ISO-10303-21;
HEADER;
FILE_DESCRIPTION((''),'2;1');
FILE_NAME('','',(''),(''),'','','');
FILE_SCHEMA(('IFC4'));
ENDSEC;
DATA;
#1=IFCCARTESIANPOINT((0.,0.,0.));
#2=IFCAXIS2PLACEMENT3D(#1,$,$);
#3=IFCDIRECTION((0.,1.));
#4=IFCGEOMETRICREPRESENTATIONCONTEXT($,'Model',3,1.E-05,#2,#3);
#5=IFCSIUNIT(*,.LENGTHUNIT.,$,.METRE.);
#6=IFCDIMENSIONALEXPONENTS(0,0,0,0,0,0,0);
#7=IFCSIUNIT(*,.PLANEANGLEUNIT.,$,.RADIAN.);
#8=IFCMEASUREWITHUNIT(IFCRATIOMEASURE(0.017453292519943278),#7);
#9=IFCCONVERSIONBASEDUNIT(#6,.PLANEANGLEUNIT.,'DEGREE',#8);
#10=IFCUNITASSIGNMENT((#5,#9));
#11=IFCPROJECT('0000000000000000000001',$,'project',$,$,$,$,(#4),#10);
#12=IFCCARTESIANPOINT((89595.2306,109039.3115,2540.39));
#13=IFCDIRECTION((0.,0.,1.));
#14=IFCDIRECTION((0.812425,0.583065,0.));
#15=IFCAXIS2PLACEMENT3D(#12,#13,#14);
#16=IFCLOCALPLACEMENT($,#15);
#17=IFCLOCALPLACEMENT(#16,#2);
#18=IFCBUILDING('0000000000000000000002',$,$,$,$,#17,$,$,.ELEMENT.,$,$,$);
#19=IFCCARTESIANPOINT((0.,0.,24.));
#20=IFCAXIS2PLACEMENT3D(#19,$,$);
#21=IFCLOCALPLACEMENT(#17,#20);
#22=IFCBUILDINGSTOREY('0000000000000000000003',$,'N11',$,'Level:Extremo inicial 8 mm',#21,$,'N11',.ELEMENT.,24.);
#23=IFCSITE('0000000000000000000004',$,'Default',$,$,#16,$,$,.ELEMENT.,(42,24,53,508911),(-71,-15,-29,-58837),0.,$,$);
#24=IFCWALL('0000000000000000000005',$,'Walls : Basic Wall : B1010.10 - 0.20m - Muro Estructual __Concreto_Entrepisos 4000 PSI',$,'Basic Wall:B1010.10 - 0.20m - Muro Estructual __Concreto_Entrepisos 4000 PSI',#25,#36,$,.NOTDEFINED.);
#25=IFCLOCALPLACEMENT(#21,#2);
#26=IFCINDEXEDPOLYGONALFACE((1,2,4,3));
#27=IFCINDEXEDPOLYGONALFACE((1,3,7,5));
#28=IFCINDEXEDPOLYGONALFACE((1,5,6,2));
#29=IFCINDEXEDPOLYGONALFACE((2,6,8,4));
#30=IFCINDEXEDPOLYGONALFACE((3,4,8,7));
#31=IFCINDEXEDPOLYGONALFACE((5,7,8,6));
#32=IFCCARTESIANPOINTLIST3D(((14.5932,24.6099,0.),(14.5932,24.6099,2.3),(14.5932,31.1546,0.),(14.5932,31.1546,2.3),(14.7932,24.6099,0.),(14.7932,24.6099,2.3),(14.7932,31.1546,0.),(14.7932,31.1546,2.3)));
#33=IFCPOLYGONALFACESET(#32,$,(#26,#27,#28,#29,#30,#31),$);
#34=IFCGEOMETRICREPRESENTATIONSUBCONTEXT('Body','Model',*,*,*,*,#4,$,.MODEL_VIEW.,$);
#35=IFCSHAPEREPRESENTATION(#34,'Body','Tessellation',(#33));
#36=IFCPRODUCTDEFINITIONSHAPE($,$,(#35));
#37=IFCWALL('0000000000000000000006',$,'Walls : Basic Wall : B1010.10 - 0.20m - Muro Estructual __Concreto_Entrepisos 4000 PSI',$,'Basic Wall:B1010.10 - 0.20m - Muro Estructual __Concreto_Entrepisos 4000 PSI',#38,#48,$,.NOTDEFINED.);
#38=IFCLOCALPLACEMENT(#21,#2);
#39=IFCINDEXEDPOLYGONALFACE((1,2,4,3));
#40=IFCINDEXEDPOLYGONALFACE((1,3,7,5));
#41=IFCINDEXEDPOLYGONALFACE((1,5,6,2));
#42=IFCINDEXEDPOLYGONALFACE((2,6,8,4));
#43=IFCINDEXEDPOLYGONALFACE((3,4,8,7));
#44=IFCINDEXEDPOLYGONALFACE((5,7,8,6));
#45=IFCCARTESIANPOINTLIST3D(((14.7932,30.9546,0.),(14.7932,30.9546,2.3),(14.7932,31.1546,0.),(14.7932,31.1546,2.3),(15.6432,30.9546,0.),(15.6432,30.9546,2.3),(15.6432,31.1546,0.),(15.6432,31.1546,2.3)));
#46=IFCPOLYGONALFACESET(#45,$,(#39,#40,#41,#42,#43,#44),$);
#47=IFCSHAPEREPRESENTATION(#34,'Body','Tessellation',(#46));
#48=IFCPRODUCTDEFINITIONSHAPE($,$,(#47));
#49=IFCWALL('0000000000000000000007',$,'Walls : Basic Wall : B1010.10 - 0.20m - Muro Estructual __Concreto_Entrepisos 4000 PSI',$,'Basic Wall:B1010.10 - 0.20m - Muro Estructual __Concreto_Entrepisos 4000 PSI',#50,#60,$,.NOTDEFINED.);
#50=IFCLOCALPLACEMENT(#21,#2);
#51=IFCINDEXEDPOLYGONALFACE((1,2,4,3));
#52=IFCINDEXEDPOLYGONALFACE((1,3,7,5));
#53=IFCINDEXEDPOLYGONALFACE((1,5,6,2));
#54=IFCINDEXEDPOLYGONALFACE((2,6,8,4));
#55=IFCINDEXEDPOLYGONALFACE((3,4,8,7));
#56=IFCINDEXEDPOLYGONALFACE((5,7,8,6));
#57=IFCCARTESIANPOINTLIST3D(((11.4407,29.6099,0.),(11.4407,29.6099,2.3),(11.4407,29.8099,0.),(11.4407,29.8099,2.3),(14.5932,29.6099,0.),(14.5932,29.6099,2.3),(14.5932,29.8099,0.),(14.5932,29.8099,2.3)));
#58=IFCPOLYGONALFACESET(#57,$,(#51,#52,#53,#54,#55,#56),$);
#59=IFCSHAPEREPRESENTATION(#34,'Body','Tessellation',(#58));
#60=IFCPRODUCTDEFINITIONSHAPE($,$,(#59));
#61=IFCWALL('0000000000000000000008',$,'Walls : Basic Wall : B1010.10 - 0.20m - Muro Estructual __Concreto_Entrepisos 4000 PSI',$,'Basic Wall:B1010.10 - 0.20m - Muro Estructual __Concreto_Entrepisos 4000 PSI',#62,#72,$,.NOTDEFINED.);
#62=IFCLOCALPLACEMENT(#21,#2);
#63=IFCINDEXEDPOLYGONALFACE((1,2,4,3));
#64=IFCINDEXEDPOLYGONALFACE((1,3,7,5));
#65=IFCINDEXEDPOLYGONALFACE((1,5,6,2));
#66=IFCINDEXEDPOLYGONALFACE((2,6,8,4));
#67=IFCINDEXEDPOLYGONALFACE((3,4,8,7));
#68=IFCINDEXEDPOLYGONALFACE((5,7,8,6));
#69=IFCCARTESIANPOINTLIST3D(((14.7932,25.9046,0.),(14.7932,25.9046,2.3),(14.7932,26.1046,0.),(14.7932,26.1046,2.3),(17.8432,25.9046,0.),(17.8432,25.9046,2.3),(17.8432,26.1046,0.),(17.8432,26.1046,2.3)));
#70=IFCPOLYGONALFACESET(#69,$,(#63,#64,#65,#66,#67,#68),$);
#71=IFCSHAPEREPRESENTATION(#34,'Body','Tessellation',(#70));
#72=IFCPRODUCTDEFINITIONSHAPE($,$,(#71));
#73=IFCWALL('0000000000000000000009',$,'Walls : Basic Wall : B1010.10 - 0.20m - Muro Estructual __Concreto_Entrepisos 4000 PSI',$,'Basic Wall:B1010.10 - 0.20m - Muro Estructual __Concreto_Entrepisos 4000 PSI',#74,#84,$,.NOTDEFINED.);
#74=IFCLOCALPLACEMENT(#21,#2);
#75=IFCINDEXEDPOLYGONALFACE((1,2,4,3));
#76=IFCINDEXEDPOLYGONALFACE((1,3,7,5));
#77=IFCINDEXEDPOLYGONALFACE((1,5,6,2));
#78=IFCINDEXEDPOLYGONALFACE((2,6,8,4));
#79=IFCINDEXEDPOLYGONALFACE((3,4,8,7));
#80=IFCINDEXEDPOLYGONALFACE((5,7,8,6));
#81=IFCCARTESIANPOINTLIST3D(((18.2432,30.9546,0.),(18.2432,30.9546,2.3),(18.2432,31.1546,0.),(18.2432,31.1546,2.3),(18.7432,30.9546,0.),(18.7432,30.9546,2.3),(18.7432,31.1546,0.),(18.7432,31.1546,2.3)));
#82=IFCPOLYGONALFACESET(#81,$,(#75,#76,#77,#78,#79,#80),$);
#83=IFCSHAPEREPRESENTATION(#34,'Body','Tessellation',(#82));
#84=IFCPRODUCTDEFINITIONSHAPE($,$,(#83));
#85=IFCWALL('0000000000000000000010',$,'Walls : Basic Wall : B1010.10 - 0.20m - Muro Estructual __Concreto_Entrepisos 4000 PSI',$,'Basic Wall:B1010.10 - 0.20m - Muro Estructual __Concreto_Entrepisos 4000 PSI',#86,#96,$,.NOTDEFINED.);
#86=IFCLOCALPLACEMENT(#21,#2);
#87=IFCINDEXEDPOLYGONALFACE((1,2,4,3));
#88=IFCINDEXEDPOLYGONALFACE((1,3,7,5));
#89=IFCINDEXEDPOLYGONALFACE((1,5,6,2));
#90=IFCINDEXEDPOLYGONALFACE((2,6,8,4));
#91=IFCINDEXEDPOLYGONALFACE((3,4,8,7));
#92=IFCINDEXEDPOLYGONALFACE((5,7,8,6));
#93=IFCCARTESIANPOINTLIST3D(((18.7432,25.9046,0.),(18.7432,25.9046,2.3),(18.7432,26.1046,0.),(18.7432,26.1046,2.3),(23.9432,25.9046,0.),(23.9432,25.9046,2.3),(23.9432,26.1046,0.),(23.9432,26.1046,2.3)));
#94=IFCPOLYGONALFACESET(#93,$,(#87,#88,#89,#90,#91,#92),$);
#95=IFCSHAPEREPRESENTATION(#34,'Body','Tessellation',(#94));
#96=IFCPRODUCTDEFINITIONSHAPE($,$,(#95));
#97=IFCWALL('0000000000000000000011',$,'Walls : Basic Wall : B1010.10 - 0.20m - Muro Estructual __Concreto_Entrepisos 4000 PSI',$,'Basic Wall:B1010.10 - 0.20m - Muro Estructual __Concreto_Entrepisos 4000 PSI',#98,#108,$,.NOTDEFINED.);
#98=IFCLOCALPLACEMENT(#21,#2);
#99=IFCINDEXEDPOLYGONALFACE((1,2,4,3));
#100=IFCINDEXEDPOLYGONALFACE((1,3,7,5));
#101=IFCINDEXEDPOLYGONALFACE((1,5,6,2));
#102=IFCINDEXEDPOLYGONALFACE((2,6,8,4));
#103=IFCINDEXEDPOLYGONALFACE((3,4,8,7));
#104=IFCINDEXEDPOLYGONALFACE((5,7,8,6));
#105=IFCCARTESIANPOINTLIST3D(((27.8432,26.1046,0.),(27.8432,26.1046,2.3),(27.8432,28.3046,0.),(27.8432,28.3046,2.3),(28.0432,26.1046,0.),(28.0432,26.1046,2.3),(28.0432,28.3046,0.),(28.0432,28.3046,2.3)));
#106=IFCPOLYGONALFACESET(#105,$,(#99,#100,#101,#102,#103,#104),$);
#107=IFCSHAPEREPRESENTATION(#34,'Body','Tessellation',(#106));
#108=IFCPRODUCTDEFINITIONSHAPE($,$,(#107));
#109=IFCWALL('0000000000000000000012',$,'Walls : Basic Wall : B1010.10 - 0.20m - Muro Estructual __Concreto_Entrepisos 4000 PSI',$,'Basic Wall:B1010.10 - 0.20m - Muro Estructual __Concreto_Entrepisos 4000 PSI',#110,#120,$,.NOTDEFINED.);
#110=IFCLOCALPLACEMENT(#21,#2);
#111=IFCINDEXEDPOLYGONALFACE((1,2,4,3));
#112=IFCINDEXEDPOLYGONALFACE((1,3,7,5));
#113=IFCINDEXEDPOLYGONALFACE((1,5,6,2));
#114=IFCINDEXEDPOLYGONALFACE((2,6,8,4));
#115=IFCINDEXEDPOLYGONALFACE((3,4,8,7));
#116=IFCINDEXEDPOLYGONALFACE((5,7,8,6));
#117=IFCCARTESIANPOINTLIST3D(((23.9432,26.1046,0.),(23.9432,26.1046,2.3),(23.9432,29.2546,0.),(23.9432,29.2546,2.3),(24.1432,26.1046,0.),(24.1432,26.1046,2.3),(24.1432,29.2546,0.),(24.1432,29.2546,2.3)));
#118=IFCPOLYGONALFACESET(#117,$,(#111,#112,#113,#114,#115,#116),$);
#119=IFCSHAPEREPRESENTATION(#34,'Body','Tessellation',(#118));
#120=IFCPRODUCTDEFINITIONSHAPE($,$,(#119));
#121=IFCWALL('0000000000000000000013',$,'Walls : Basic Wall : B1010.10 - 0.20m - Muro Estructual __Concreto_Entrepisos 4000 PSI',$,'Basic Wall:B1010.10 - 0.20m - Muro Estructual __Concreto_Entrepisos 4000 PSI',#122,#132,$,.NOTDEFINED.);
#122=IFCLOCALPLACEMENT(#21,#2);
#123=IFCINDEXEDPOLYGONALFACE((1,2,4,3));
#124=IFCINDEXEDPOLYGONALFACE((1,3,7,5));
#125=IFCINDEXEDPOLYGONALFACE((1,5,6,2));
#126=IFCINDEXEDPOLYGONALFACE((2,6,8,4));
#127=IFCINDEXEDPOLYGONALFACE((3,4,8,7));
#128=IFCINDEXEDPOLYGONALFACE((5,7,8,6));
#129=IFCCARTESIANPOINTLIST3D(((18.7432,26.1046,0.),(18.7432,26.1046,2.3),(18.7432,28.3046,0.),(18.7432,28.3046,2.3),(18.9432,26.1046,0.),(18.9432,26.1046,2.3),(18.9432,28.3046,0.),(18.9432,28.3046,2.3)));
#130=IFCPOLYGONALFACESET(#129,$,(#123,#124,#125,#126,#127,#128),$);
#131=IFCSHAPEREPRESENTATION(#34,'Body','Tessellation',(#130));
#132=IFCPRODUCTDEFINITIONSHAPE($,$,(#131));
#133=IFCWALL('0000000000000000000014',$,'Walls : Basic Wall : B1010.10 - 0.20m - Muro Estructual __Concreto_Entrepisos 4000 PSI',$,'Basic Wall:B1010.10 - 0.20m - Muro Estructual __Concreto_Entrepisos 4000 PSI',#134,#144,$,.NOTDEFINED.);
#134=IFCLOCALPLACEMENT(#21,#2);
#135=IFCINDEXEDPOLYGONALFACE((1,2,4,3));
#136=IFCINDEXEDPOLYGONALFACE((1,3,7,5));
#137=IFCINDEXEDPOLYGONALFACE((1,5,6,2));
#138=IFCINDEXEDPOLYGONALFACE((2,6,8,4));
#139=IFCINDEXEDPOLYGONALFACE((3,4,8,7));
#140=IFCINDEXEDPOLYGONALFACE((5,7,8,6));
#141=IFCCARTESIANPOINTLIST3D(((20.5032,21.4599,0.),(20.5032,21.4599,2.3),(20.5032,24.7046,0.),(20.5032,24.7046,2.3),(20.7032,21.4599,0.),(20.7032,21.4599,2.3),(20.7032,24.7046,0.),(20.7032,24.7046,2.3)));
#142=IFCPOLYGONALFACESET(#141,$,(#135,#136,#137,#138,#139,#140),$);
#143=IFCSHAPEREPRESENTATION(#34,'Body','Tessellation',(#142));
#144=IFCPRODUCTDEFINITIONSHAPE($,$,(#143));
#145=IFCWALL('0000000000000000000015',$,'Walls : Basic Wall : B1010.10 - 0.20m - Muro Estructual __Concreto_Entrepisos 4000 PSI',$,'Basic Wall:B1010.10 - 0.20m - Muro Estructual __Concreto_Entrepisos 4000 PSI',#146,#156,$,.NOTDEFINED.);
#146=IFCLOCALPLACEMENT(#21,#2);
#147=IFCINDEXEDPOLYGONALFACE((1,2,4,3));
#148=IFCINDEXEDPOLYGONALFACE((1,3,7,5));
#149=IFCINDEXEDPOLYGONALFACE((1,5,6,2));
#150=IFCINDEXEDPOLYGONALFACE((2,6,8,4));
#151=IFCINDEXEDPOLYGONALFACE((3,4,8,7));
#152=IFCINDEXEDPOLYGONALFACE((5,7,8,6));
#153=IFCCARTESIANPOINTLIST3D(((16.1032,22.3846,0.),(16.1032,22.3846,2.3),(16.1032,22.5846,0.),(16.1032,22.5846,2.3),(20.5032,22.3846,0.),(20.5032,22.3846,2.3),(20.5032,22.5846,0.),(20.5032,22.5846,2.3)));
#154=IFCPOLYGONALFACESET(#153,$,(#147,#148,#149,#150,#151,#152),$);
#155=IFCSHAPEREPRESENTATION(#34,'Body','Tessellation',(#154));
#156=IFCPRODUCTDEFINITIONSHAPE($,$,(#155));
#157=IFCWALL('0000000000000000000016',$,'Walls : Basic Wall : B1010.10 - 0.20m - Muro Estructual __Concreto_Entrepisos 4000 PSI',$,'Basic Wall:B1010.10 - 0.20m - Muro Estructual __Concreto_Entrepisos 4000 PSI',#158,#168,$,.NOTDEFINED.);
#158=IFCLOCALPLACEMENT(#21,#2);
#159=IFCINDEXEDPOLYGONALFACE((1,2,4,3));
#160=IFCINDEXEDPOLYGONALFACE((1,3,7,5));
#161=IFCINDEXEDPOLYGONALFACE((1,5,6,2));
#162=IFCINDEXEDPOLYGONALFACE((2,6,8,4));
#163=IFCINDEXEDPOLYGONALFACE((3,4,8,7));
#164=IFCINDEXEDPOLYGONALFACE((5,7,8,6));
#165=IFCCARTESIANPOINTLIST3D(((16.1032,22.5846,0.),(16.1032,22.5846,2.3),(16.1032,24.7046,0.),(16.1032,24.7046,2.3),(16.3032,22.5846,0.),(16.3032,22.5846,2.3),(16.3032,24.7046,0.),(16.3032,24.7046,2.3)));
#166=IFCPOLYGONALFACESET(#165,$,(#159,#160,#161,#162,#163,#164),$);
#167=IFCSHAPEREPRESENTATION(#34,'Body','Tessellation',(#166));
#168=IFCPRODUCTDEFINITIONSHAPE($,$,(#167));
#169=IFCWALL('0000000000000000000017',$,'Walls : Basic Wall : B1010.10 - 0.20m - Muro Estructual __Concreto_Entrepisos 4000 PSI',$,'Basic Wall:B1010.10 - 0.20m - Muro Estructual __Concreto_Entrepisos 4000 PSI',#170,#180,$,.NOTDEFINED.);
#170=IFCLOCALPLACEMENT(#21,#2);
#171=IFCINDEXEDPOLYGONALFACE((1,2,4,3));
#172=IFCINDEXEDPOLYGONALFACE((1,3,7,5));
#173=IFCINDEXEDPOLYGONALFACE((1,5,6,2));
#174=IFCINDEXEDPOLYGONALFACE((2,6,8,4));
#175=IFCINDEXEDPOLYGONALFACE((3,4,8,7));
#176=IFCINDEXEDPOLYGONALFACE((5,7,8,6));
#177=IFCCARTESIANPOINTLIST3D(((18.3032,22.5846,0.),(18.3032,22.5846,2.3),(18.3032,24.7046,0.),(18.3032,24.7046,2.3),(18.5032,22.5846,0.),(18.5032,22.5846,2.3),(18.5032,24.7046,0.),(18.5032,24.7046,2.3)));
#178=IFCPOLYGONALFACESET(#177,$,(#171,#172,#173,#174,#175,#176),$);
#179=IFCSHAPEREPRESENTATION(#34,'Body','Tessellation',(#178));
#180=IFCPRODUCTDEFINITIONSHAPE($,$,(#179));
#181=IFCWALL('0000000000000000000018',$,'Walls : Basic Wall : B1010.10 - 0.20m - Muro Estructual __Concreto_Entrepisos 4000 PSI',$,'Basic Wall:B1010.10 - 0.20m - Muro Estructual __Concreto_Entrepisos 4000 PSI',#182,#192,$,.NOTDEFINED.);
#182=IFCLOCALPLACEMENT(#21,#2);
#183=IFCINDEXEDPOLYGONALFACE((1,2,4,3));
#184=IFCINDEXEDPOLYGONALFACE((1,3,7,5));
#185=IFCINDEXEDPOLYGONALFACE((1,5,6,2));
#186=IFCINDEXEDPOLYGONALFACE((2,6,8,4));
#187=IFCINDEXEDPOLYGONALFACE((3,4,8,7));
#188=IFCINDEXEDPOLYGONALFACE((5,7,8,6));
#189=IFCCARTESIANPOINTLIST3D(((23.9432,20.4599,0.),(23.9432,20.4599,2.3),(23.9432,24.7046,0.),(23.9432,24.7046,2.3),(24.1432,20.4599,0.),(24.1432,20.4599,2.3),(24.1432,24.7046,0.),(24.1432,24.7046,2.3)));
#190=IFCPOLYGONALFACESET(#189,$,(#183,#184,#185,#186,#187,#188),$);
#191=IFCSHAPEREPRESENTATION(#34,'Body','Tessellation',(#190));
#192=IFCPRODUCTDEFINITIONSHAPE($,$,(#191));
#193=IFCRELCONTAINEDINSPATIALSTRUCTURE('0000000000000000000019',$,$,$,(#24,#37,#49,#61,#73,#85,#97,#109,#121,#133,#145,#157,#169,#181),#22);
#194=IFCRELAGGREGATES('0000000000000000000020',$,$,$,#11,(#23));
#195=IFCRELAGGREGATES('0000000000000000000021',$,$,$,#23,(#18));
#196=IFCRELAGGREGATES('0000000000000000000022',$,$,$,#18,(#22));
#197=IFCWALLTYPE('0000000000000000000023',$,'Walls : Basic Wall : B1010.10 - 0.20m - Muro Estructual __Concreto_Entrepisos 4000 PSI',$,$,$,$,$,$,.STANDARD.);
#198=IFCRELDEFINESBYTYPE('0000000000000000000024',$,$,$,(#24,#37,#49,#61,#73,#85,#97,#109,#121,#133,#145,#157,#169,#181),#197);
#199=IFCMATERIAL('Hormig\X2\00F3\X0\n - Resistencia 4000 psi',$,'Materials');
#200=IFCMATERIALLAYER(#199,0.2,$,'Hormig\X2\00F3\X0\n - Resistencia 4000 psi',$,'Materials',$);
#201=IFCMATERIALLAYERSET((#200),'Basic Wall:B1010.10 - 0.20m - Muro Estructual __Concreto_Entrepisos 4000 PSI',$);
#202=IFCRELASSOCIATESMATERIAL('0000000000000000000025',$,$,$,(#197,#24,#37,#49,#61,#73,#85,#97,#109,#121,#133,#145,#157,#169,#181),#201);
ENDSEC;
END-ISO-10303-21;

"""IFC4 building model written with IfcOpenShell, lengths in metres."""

from ifc_helpers import new_model, entity, si_unit, converted_unit, direction, frame, frame_2d, origin, place, context, subcontext, project, spatial, rectangle, extrude, material, layer, layer_set, layer_usage, type_object, element, save


model = new_model("IFC4")

# Units and contexts
model_context = context("Model", 3, precision=1e-05, world=origin(), true_north=direction((0.0, 1.0)))
body_context = subcontext(model_context, "Body", "Model", "MODEL_VIEW")
ifc_project = project(units=[si_unit("LENGTHUNIT", "METRE"), converted_unit("PLANEANGLEUNIT", "DEGREE", entity("IfcRatioMeasure", 0.017453292519943278), si_unit("PLANEANGLEUNIT", "RADIAN"), dimensions=[0, 0, 0, 0, 0, 0, 0])], contexts=[model_context])

# Site, building, storey
site_placement = place(None, frame((89595.2306, 109039.3115, 2540.39), z_axis=(0.0, 0.0, 1.0), x_axis=(0.812425, 0.583065, 0.0)))
site = spatial("IfcSite", under=ifc_project, at=site_placement, Name="Default", CompositionType="ELEMENT", RefLatitude=(42, 24, 53, 508911), RefLongitude=(-71, -15, -29, -58837), RefElevation=0.0)
building_placement = place(site_placement, origin())
building = spatial("IfcBuilding", under=site, at=building_placement, CompositionType="ELEMENT")
storey_placement = place(building_placement, frame((0.0, 0.0, 24.0)))
storey = spatial("IfcBuildingStorey", under=building, at=storey_placement, Name="N11", ObjectType="Level:Extremo inicial 8 mm", LongName="N11", CompositionType="ELEMENT", Elevation=24.0)

# Walls
ifc_material_1 = material(Name="Hormigón - Resistencia 4000 psi", Category="Materials")
ifc_layer_1 = layer(ifc_material_1, 0.2, Name="Hormigón - Resistencia 4000 psi", Category="Materials")
ifc_layer_set_1 = layer_set([ifc_layer_1], Name="Basic Wall:B1010.10 - 0.20m - Muro Estructual __Concreto_Entrepisos 4000 PSI")
ifc_layer_usage_1 = layer_usage(ifc_layer_set_1, "AXIS2", "NEGATIVE", 0.1)
wall_type_1 = type_object("IfcWallType", Name="Walls : Basic Wall : B1010.10 - 0.20m - Muro Estructual __Concreto_Entrepisos 4000 PSI", PredefinedType="STANDARD", material=ifc_layer_set_1)
wall_1_placement = place(storey_placement, frame((14.6932, 24.6099, 0.0), z_axis=(0.0, 0.0, 1.0), x_axis=(0.0, 1.0, 0.0)))
element("IfcWall", 1, at=wall_1_placement, inside=storey, type_object=wall_type_1, material=ifc_layer_usage_1, Name="Walls : Basic Wall : B1010.10 - 0.20m - Muro Estructual __Concreto_Entrepisos 4000 PSI", ObjectType="Basic Wall:B1010.10 - 0.20m - Muro Estructual __Concreto_Entrepisos 4000 PSI", PredefinedType="NOTDEFINED", context=body_context, shape_type="SweptSolid", body=[
    extrude(rectangle(XDim=6.5447, YDim=0.2, at=frame_2d((3.2724, 0.0), x_axis=(-1.0, 0.0))), origin(), (0.0, 0.0, 1.0), 2.3),
])
ifc_layer_usage_2 = layer_usage(ifc_layer_set_1, "AXIS2", "NEGATIVE", 0.1)
wall_2_placement = place(storey_placement, frame((15.6432, 31.0546, 0.0), z_axis=(0.0, 0.0, 1.0), x_axis=(-1.0, 0.0, 0.0)))
element("IfcWall", 2, at=wall_2_placement, inside=storey, type_object=wall_type_1, material=ifc_layer_usage_2, Name="Walls : Basic Wall : B1010.10 - 0.20m - Muro Estructual __Concreto_Entrepisos 4000 PSI", ObjectType="Basic Wall:B1010.10 - 0.20m - Muro Estructual __Concreto_Entrepisos 4000 PSI", PredefinedType="NOTDEFINED", context=body_context, shape_type="SweptSolid", body=[
    extrude(rectangle(XDim=0.85, YDim=0.2, at=frame_2d((0.425, 0.0), x_axis=(-1.0, 0.0))), origin(), (0.0, 0.0, 1.0), 2.3),
])
ifc_layer_usage_3 = layer_usage(ifc_layer_set_1, "AXIS2", "NEGATIVE", 0.1)
wall_3_placement = place(storey_placement, frame((11.4407, 29.7099, 0.0)))
element("IfcWall", 3, at=wall_3_placement, inside=storey, type_object=wall_type_1, material=ifc_layer_usage_3, Name="Walls : Basic Wall : B1010.10 - 0.20m - Muro Estructual __Concreto_Entrepisos 4000 PSI", ObjectType="Basic Wall:B1010.10 - 0.20m - Muro Estructual __Concreto_Entrepisos 4000 PSI", PredefinedType="NOTDEFINED", context=body_context, shape_type="SweptSolid", body=[
    extrude(rectangle(XDim=3.1525, YDim=0.2, at=frame_2d((1.5763, 0.0), x_axis=(-1.0, 0.0))), origin(), (0.0, 0.0, 1.0), 2.3),
])
ifc_layer_usage_4 = layer_usage(ifc_layer_set_1, "AXIS2", "NEGATIVE", 0.1)
wall_4_placement = place(storey_placement, frame((17.8432, 26.0046, 0.0), z_axis=(0.0, 0.0, 1.0), x_axis=(-1.0, 0.0, 0.0)))
element("IfcWall", 4, at=wall_4_placement, inside=storey, type_object=wall_type_1, material=ifc_layer_usage_4, Name="Walls : Basic Wall : B1010.10 - 0.20m - Muro Estructual __Concreto_Entrepisos 4000 PSI", ObjectType="Basic Wall:B1010.10 - 0.20m - Muro Estructual __Concreto_Entrepisos 4000 PSI", PredefinedType="NOTDEFINED", context=body_context, shape_type="SweptSolid", body=[
    extrude(rectangle(XDim=3.05, YDim=0.2, at=frame_2d((1.525, 0.0), x_axis=(-1.0, 0.0))), origin(), (0.0, 0.0, 1.0), 2.3),
])
ifc_layer_usage_5 = layer_usage(ifc_layer_set_1, "AXIS2", "NEGATIVE", 0.1)
wall_5_placement = place(storey_placement, frame((18.7432, 31.0546, 0.0), z_axis=(0.0, 0.0, 1.0), x_axis=(-1.0, 0.0, 0.0)))
element("IfcWall", 5, at=wall_5_placement, inside=storey, type_object=wall_type_1, material=ifc_layer_usage_5, Name="Walls : Basic Wall : B1010.10 - 0.20m - Muro Estructual __Concreto_Entrepisos 4000 PSI", ObjectType="Basic Wall:B1010.10 - 0.20m - Muro Estructual __Concreto_Entrepisos 4000 PSI", PredefinedType="NOTDEFINED", context=body_context, shape_type="SweptSolid", body=[
    extrude(rectangle(XDim=0.5, YDim=0.2, at=frame_2d((0.25, 0.0), x_axis=(-1.0, 0.0))), origin(), (0.0, 0.0, 1.0), 2.3),
])
ifc_layer_usage_6 = layer_usage(ifc_layer_set_1, "AXIS2", "NEGATIVE", 0.1)
wall_6_placement = place(storey_placement, frame((18.7432, 26.0046, 0.0)))
element("IfcWall", 6, at=wall_6_placement, inside=storey, type_object=wall_type_1, material=ifc_layer_usage_6, Name="Walls : Basic Wall : B1010.10 - 0.20m - Muro Estructual __Concreto_Entrepisos 4000 PSI", ObjectType="Basic Wall:B1010.10 - 0.20m - Muro Estructual __Concreto_Entrepisos 4000 PSI", PredefinedType="NOTDEFINED", context=body_context, shape_type="SweptSolid", body=[
    extrude(rectangle(XDim=5.2, YDim=0.2, at=frame_2d((2.6, 0.0), x_axis=(-1.0, 0.0))), origin(), (0.0, 0.0, 1.0), 2.3),
])
ifc_layer_usage_7 = layer_usage(ifc_layer_set_1, "AXIS2", "NEGATIVE", 0.1)
wall_7_placement = place(storey_placement, frame((27.9432, 28.3046, 0.0), z_axis=(0.0, 0.0, 1.0), x_axis=(0.0, -1.0, 0.0)))
element("IfcWall", 7, at=wall_7_placement, inside=storey, type_object=wall_type_1, material=ifc_layer_usage_7, Name="Walls : Basic Wall : B1010.10 - 0.20m - Muro Estructual __Concreto_Entrepisos 4000 PSI", ObjectType="Basic Wall:B1010.10 - 0.20m - Muro Estructual __Concreto_Entrepisos 4000 PSI", PredefinedType="NOTDEFINED", context=body_context, shape_type="SweptSolid", body=[
    extrude(rectangle(XDim=2.2, YDim=0.2, at=frame_2d((1.1, 0.0), x_axis=(-1.0, 0.0))), origin(), (0.0, 0.0, 1.0), 2.3),
])
ifc_layer_usage_8 = layer_usage(ifc_layer_set_1, "AXIS2", "NEGATIVE", 0.1)
wall_8_placement = place(storey_placement, frame((24.0432, 26.1046, 0.0), z_axis=(0.0, 0.0, 1.0), x_axis=(0.0, 1.0, 0.0)))
element("IfcWall", 8, at=wall_8_placement, inside=storey, type_object=wall_type_1, material=ifc_layer_usage_8, Name="Walls : Basic Wall : B1010.10 - 0.20m - Muro Estructual __Concreto_Entrepisos 4000 PSI", ObjectType="Basic Wall:B1010.10 - 0.20m - Muro Estructual __Concreto_Entrepisos 4000 PSI", PredefinedType="NOTDEFINED", context=body_context, shape_type="SweptSolid", body=[
    extrude(rectangle(XDim=3.15, YDim=0.2, at=frame_2d((1.575, 0.0), x_axis=(-1.0, 0.0))), origin(), (0.0, 0.0, 1.0), 2.3),
])
ifc_layer_usage_9 = layer_usage(ifc_layer_set_1, "AXIS2", "NEGATIVE", 0.1)
wall_9_placement = place(storey_placement, frame((18.8432, 28.3046, 0.0), z_axis=(0.0, 0.0, 1.0), x_axis=(0.0, -1.0, 0.0)))
element("IfcWall", 9, at=wall_9_placement, inside=storey, type_object=wall_type_1, material=ifc_layer_usage_9, Name="Walls : Basic Wall : B1010.10 - 0.20m - Muro Estructual __Concreto_Entrepisos 4000 PSI", ObjectType="Basic Wall:B1010.10 - 0.20m - Muro Estructual __Concreto_Entrepisos 4000 PSI", PredefinedType="NOTDEFINED", context=body_context, shape_type="SweptSolid", body=[
    extrude(rectangle(XDim=2.2, YDim=0.2, at=frame_2d((1.1, 0.0), x_axis=(-1.0, 0.0))), origin(), (0.0, 0.0, 1.0), 2.3),
])
ifc_layer_usage_10 = layer_usage(ifc_layer_set_1, "AXIS2", "NEGATIVE", 0.1)
wall_10_placement = place(storey_placement, frame((20.6032, 21.4599, 0.0), z_axis=(0.0, 0.0, 1.0), x_axis=(0.0, 1.0, 0.0)))
element("IfcWall", 10, at=wall_10_placement, inside=storey, type_object=wall_type_1, material=ifc_layer_usage_10, Name="Walls : Basic Wall : B1010.10 - 0.20m - Muro Estructual __Concreto_Entrepisos 4000 PSI", ObjectType="Basic Wall:B1010.10 - 0.20m - Muro Estructual __Concreto_Entrepisos 4000 PSI", PredefinedType="NOTDEFINED", context=body_context, shape_type="SweptSolid", body=[
    extrude(rectangle(XDim=3.2447, YDim=0.2, at=frame_2d((1.6224, 0.0), x_axis=(-1.0, 0.0))), origin(), (0.0, 0.0, 1.0), 2.3),
])
ifc_layer_usage_11 = layer_usage(ifc_layer_set_1, "AXIS2", "NEGATIVE", 0.1)
wall_11_placement = place(storey_placement, frame((20.5032, 22.4846, 0.0), z_axis=(0.0, 0.0, 1.0), x_axis=(-1.0, 0.0, 0.0)))
element("IfcWall", 11, at=wall_11_placement, inside=storey, type_object=wall_type_1, material=ifc_layer_usage_11, Name="Walls : Basic Wall : B1010.10 - 0.20m - Muro Estructual __Concreto_Entrepisos 4000 PSI", ObjectType="Basic Wall:B1010.10 - 0.20m - Muro Estructual __Concreto_Entrepisos 4000 PSI", PredefinedType="NOTDEFINED", context=body_context, shape_type="SweptSolid", body=[
    extrude(rectangle(XDim=4.4, YDim=0.2, at=frame_2d((2.2, 0.0), x_axis=(-1.0, 0.0))), origin(), (0.0, 0.0, 1.0), 2.3),
])
ifc_layer_usage_12 = layer_usage(ifc_layer_set_1, "AXIS2", "NEGATIVE", 0.1)
wall_12_placement = place(storey_placement, frame((16.2032, 22.5846, 0.0), z_axis=(0.0, 0.0, 1.0), x_axis=(0.0, 1.0, 0.0)))
element("IfcWall", 12, at=wall_12_placement, inside=storey, type_object=wall_type_1, material=ifc_layer_usage_12, Name="Walls : Basic Wall : B1010.10 - 0.20m - Muro Estructual __Concreto_Entrepisos 4000 PSI", ObjectType="Basic Wall:B1010.10 - 0.20m - Muro Estructual __Concreto_Entrepisos 4000 PSI", PredefinedType="NOTDEFINED", context=body_context, shape_type="SweptSolid", body=[
    extrude(rectangle(XDim=2.12, YDim=0.2, at=frame_2d((1.06, 0.0), x_axis=(-1.0, 0.0))), origin(), (0.0, 0.0, 1.0), 2.3),
])
ifc_layer_usage_13 = layer_usage(ifc_layer_set_1, "AXIS2", "NEGATIVE", 0.1)
wall_13_placement = place(storey_placement, frame((18.4032, 24.7046, 0.0), z_axis=(0.0, 0.0, 1.0), x_axis=(0.0, -1.0, 0.0)))
element("IfcWall", 13, at=wall_13_placement, inside=storey, type_object=wall_type_1, material=ifc_layer_usage_13, Name="Walls : Basic Wall : B1010.10 - 0.20m - Muro Estructual __Concreto_Entrepisos 4000 PSI", ObjectType="Basic Wall:B1010.10 - 0.20m - Muro Estructual __Concreto_Entrepisos 4000 PSI", PredefinedType="NOTDEFINED", context=body_context, shape_type="SweptSolid", body=[
    extrude(rectangle(XDim=2.12, YDim=0.2, at=frame_2d((1.06, 0.0), x_axis=(-1.0, 0.0))), origin(), (0.0, 0.0, 1.0), 2.3),
])
ifc_layer_usage_14 = layer_usage(ifc_layer_set_1, "AXIS2", "NEGATIVE", 0.1)
wall_14_placement = place(storey_placement, frame((24.0432, 20.4599, 0.0), z_axis=(0.0, 0.0, 1.0), x_axis=(0.0, 1.0, 0.0)))
element("IfcWall", 14, at=wall_14_placement, inside=storey, type_object=wall_type_1, material=ifc_layer_usage_14, Name="Walls : Basic Wall : B1010.10 - 0.20m - Muro Estructual __Concreto_Entrepisos 4000 PSI", ObjectType="Basic Wall:B1010.10 - 0.20m - Muro Estructual __Concreto_Entrepisos 4000 PSI", PredefinedType="NOTDEFINED", context=body_context, shape_type="SweptSolid", body=[
    extrude(rectangle(XDim=4.2447, YDim=0.2, at=frame_2d((2.1224, 0.0), x_axis=(-1.0, 0.0))), origin(), (0.0, 0.0, 1.0), 2.3),
])

save(model, "model.ifc")
